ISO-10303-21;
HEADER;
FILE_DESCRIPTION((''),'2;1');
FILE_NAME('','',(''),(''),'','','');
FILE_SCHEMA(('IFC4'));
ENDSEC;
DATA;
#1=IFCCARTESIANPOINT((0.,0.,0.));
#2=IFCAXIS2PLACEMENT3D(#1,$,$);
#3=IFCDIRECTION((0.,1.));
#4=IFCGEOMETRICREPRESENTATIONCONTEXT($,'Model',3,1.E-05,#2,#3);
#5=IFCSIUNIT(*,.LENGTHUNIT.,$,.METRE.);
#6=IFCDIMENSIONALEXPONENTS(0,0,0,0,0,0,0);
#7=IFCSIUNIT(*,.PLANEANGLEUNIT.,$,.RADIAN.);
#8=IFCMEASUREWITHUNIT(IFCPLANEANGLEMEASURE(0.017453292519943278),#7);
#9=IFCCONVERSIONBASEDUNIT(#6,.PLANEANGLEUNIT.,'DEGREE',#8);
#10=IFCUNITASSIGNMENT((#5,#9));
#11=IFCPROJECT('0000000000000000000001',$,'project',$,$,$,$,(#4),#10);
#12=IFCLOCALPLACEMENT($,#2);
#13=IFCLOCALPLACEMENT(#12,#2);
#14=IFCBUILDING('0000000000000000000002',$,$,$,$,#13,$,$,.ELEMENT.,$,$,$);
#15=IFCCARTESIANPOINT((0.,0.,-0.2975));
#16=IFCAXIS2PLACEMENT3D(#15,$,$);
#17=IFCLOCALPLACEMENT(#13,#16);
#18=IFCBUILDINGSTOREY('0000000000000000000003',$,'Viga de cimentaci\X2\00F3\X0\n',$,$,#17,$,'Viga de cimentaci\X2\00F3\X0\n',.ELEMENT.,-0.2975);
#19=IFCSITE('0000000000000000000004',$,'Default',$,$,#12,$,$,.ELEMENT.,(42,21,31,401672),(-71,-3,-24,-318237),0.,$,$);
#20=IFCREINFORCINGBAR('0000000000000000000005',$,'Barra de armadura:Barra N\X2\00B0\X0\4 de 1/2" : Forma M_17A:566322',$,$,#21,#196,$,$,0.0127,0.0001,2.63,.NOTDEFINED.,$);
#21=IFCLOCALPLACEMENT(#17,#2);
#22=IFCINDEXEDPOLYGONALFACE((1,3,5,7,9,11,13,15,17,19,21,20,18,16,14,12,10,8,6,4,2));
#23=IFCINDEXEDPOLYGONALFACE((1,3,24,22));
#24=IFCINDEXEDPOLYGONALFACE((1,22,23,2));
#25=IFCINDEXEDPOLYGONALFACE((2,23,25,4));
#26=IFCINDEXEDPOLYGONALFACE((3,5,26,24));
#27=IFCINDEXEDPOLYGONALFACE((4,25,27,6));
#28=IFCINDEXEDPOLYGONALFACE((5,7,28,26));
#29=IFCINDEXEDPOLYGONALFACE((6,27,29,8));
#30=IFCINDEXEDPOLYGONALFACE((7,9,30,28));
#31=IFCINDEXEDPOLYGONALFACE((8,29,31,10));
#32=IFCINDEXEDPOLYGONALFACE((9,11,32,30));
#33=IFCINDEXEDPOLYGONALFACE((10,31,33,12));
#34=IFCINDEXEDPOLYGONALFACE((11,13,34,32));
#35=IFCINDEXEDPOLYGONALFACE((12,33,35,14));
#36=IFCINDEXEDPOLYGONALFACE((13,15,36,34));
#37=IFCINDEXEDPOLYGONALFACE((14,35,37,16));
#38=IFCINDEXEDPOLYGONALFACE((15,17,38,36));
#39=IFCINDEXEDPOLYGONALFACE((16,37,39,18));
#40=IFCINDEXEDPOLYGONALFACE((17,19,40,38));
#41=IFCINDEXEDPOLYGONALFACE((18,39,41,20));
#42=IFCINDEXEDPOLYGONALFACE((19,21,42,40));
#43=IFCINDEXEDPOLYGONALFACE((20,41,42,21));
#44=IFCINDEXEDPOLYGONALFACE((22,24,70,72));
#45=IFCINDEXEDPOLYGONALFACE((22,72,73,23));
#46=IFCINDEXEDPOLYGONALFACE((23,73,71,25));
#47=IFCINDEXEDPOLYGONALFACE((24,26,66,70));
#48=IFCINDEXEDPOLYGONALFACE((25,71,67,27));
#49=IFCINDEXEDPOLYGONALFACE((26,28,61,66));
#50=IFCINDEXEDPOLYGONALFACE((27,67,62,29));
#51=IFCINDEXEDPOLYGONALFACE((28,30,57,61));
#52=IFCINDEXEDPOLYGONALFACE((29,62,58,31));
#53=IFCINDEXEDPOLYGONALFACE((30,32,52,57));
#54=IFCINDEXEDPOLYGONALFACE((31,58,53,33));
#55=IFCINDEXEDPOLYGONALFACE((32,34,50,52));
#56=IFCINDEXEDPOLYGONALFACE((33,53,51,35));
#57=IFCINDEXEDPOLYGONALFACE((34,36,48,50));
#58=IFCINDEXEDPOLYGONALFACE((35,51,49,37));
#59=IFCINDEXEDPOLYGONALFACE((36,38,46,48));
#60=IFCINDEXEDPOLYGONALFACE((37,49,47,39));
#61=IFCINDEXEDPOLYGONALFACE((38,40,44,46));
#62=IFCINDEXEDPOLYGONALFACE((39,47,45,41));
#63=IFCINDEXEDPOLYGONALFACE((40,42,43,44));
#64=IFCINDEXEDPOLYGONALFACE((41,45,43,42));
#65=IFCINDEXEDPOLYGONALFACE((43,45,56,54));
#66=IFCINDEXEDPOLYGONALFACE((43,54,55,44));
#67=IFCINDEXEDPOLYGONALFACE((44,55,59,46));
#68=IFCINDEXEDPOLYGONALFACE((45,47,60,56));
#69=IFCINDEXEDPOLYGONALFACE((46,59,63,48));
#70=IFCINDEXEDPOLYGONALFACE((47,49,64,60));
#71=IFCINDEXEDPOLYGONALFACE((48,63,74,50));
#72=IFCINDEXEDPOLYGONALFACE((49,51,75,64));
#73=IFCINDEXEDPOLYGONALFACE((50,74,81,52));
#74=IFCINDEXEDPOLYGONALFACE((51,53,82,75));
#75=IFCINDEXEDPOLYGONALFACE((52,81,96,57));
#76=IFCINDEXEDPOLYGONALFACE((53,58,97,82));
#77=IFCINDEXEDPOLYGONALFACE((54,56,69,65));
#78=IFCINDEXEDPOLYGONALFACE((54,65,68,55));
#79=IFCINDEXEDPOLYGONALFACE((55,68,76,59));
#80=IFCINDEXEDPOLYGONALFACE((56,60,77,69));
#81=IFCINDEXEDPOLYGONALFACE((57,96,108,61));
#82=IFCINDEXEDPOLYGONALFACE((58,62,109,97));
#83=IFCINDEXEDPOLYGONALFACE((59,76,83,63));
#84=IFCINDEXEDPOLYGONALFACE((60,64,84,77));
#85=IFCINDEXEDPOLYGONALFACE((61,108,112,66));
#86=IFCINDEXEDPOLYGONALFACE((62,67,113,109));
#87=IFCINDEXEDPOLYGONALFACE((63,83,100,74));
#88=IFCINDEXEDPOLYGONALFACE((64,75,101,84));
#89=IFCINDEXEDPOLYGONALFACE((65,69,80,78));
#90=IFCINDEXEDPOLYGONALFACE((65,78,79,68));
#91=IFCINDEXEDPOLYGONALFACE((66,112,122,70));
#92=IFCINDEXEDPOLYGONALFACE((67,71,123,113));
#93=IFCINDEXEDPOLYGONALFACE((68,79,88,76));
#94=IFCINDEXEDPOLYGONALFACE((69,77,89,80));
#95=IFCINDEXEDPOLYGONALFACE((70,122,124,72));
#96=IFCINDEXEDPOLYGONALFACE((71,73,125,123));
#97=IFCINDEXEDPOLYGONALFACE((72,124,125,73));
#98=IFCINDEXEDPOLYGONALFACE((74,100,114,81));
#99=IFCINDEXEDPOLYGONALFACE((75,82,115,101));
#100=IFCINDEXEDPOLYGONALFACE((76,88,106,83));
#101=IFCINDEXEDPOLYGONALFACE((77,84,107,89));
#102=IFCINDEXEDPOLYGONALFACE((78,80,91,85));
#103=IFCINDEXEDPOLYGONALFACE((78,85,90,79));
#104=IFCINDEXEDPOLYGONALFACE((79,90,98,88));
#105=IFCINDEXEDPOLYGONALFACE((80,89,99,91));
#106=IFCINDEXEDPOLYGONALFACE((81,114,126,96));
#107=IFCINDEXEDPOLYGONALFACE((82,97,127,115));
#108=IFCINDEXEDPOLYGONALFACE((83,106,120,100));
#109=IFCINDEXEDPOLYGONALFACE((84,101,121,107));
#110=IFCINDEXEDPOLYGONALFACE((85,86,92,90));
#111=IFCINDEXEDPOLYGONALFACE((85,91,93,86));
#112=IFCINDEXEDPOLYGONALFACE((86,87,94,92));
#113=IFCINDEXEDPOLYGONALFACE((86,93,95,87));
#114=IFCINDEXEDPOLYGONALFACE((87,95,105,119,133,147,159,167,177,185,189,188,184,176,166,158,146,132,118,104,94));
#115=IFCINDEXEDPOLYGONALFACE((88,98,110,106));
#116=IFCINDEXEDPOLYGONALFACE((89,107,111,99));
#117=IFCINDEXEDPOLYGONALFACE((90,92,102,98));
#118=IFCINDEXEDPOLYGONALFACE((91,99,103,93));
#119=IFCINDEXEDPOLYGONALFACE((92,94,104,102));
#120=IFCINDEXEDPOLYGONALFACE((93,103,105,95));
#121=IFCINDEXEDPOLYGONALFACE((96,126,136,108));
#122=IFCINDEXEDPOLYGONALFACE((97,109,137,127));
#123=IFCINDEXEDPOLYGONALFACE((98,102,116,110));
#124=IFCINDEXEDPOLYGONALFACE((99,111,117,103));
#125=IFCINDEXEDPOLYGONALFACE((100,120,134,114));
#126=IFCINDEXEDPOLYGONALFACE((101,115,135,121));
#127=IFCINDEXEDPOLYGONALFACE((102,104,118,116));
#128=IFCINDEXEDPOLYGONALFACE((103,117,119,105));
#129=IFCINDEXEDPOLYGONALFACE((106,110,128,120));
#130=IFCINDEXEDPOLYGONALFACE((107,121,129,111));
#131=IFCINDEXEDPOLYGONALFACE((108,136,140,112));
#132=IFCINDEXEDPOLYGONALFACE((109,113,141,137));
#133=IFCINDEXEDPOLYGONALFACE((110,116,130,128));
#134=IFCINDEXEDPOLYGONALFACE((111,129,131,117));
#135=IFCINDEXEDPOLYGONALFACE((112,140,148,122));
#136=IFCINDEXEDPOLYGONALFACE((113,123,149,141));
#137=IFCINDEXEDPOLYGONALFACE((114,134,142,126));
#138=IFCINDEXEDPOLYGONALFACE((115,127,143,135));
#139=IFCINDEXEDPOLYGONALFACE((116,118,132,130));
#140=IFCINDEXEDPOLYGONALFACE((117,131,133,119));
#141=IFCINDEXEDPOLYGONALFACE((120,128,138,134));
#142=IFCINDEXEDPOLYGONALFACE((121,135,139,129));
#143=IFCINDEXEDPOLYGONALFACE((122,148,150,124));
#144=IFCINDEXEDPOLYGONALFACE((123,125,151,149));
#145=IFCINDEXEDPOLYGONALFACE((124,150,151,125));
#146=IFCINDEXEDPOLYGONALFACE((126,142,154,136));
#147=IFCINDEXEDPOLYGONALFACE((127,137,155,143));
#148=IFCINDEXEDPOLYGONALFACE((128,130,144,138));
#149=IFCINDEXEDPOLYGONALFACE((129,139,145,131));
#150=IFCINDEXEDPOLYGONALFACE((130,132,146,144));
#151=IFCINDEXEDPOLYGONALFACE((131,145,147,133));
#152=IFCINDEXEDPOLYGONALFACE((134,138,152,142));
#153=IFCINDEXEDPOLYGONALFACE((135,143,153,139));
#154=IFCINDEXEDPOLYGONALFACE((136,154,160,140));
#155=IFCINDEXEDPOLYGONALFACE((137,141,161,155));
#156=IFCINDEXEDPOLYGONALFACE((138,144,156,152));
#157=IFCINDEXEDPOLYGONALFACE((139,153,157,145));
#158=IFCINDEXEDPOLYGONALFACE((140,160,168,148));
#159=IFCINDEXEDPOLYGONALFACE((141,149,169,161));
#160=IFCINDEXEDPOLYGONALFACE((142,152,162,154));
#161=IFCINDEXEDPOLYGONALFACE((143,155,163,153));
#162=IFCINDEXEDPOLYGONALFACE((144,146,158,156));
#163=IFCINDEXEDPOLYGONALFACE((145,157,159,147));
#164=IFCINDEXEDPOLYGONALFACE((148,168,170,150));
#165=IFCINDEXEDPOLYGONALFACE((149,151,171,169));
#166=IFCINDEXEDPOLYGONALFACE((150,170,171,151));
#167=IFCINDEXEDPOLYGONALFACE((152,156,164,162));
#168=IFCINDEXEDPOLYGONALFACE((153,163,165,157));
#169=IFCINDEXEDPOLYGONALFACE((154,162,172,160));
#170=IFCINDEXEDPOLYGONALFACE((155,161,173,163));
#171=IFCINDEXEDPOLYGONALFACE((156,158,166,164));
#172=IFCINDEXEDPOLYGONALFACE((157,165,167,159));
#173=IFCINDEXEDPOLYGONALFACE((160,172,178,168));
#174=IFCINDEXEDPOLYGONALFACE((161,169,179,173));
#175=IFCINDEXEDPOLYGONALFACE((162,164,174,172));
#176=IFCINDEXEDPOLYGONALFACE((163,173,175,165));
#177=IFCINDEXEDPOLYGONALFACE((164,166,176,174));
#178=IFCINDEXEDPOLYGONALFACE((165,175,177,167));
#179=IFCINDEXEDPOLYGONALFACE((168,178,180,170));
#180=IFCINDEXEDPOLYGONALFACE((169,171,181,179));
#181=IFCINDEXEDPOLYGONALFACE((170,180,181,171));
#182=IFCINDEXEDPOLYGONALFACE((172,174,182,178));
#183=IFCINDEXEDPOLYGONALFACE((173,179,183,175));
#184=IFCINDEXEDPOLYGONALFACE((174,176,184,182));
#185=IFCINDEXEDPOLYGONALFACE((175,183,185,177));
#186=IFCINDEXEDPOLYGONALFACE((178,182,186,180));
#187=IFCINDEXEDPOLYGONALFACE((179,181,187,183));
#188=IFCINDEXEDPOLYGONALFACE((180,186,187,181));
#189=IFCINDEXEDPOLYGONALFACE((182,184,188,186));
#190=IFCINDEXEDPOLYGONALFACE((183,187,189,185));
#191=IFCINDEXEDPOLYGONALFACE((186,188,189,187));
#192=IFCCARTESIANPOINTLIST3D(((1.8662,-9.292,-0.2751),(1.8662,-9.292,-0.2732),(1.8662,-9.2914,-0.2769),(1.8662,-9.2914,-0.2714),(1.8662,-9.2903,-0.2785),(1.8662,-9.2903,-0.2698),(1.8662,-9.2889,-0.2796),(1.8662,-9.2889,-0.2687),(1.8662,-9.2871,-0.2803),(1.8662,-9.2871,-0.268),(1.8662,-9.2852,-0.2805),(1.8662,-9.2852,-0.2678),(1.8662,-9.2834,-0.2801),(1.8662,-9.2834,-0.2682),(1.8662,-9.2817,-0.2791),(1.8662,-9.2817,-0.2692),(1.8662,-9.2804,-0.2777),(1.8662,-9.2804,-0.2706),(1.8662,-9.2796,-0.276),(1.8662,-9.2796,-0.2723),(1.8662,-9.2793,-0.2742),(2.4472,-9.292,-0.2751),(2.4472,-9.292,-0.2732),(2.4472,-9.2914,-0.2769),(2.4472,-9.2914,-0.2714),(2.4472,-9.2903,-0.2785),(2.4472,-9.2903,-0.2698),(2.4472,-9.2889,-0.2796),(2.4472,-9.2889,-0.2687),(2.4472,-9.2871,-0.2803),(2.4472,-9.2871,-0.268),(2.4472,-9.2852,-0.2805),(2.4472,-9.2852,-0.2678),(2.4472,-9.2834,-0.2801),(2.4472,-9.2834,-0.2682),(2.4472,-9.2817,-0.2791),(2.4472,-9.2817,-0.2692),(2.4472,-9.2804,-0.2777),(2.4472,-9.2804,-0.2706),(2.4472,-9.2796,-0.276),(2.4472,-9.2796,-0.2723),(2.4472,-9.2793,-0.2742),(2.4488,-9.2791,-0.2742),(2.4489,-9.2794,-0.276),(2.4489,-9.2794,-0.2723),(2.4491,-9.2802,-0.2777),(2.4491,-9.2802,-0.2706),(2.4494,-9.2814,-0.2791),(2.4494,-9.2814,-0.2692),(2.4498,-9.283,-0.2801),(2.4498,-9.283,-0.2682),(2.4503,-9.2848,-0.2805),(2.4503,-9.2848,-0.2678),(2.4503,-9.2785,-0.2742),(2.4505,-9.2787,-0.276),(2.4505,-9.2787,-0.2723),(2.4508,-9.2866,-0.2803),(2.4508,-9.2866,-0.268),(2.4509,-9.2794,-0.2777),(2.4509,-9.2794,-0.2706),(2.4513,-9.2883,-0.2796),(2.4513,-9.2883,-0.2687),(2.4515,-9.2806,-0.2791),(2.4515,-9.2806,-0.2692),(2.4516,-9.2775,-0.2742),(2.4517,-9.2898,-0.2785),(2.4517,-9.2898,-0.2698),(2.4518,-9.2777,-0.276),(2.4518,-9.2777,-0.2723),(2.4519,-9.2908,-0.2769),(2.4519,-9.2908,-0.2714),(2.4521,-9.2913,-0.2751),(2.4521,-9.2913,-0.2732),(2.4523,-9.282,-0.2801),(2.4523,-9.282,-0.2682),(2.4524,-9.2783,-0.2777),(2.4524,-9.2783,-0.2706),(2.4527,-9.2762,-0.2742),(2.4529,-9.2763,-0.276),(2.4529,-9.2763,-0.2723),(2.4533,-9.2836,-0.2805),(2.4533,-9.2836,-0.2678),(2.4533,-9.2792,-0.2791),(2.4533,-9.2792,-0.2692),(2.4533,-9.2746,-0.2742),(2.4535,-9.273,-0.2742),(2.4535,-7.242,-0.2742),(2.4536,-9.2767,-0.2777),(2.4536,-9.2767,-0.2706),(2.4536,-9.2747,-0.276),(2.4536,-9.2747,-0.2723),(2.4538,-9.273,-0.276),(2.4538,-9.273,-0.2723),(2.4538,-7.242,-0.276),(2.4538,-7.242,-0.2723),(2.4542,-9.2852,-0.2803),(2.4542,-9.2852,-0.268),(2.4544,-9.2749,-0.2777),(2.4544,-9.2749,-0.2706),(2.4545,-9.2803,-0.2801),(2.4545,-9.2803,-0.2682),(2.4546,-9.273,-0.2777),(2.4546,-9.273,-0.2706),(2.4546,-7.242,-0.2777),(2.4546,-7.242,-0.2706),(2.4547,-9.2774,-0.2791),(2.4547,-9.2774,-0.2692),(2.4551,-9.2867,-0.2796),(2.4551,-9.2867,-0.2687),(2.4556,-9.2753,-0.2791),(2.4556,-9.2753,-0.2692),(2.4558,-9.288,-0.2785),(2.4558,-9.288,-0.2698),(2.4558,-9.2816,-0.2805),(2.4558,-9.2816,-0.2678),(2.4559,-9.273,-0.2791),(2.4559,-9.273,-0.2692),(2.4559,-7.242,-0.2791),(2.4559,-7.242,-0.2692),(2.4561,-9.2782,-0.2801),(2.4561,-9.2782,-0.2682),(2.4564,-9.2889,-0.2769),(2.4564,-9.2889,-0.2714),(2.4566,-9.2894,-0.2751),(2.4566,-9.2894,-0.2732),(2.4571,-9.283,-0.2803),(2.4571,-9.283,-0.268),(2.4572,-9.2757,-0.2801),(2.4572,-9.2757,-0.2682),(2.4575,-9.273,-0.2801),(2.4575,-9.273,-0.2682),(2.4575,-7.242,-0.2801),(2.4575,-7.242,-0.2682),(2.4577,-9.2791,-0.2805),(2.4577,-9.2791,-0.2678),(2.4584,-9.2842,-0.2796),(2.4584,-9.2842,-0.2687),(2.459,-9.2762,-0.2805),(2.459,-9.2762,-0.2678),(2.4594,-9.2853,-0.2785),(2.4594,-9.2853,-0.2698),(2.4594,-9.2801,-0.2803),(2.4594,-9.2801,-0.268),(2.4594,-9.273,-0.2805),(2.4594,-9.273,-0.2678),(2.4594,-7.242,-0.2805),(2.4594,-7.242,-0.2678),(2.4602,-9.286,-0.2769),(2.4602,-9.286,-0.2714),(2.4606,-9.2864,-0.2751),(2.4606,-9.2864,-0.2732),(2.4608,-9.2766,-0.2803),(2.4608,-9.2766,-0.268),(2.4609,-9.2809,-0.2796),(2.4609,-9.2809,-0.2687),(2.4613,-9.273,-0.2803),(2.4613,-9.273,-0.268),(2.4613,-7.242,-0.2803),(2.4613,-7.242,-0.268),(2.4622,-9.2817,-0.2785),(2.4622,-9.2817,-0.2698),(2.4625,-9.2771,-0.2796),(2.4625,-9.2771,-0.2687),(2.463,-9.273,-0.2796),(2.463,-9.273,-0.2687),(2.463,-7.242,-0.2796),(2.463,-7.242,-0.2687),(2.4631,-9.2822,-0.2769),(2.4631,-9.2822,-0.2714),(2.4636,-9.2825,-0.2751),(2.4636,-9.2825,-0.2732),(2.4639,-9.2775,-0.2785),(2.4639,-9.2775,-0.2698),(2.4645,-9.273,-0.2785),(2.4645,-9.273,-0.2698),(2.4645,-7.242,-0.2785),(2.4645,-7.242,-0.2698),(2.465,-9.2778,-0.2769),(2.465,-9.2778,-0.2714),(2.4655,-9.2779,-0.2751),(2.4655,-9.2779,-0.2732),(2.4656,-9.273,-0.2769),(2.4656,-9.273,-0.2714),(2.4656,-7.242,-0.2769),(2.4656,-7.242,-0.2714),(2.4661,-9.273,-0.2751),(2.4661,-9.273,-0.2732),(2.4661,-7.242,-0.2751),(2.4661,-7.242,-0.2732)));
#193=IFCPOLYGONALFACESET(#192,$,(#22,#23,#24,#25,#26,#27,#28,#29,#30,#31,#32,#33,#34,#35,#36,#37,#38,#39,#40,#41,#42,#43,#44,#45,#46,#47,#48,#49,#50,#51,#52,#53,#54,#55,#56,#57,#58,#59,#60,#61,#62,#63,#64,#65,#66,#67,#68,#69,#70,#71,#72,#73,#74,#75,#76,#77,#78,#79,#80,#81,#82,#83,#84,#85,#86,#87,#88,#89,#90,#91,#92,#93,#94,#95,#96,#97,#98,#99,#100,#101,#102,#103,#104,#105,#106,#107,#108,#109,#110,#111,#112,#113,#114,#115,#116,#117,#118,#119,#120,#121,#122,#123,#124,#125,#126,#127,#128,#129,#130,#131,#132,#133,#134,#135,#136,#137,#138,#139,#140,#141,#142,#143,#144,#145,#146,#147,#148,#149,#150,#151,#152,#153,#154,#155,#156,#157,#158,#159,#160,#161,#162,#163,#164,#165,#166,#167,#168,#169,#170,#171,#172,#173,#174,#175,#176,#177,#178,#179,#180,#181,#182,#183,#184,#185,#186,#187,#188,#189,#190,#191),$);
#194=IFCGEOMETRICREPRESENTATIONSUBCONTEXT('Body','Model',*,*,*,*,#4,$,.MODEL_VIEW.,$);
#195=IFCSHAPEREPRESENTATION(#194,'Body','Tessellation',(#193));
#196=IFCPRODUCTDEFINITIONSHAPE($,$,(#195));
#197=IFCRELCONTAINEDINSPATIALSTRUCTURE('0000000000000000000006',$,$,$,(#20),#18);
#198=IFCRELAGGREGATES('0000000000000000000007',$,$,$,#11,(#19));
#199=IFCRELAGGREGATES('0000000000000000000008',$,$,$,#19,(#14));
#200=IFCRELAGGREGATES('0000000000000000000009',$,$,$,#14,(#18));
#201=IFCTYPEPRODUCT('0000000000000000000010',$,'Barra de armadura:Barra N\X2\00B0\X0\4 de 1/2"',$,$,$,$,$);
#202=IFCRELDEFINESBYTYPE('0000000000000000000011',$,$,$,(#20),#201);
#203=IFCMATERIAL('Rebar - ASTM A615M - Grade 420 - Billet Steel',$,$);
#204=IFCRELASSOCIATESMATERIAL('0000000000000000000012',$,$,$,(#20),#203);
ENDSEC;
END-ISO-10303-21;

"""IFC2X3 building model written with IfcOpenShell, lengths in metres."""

from ifc_helpers import new_model, entity, si_unit, converted_unit, direction, frame, origin, place, context, subcontext, project, spatial, material, type_object, element, save


model = new_model("IFC2X3")

# Units and contexts
model_context = context("Model", 3, precision=1e-05, world=origin(), true_north=direction((0.0, 1.0)))
body_context = subcontext(model_context, "Body", "Model", "MODEL_VIEW")
ifc_project = project(units=[si_unit("LENGTHUNIT", "METRE"), converted_unit("PLANEANGLEUNIT", "DEGREE", entity("IfcPlaneAngleMeasure", 0.017453292519943278), si_unit("PLANEANGLEUNIT", "RADIAN"), dimensions=[0, 0, 0, 0, 0, 0, 0])], contexts=[model_context])

# Site, building, storey
site_placement = place(None, origin())
site = spatial("IfcSite", under=ifc_project, at=site_placement, Name="Default", CompositionType="ELEMENT", RefLatitude=(42, 21, 31, 401672), RefLongitude=(-71, -3, -24, -318237), RefElevation=0.0)
building_placement = place(site_placement, origin())
building = spatial("IfcBuilding", under=site, at=building_placement, CompositionType="ELEMENT")
storey_placement = place(building_placement, frame((0.0, 0.0, -0.2975)))
storey = spatial("IfcBuildingStorey", under=building, at=storey_placement, Name="Viga de cimentación", LongName="Viga de cimentación", CompositionType="ELEMENT", Elevation=-0.2975)

# Reinforcing bar
ifc_material = material(Name="Rebar - ASTM A615M - Grade 420 - Billet Steel")
type_product_1 = type_object("IfcTypeProduct", Name="Barra de armadura:Barra N°4 de 1/2\"")
reinforcing_bar_1_placement = place(storey_placement, origin())
element("IfcReinforcingBar", 1, at=reinforcing_bar_1_placement, inside=storey, type_object=type_product_1, material=ifc_material, Name="Barra de armadura:Barra N°4 de 1/2\" : Forma M_17A:566322", BarLength=2.63, BarRole="NOTDEFINED", CrossSectionArea=0.0001, NominalDiameter=0.0127, context=body_context, shape_type="AdvancedSweptSolid", body=[
    entity("IfcSweptDiskSolid", entity("IfcCompositeCurve", [entity("IfcCompositeCurveSegment", "CONTINUOUS", True, entity("IfcPolyline", [entity("IfcCartesianPoint", [1.8662, -9.2857, -0.2742]), entity("IfcCartesianPoint", [2.4472, -9.2857, -0.2742])])), entity("IfcCompositeCurveSegment", "CONTINUOUS", True, entity("IfcTrimmedCurve", entity("IfcCircle", entity("IfcAxis2Placement3D", entity("IfcCartesianPoint", [2.4472, -9.273, -0.2742])), 0.0127), [entity("IfcParameterValue", 270.0)], [entity("IfcParameterValue", 360.0)], True, "PARAMETER")), entity("IfcCompositeCurveSegment", "CONTINUOUS", True, entity("IfcPolyline", [entity("IfcCartesianPoint", [2.4599, -9.273, -0.2742]), entity("IfcCartesianPoint", [2.4599, -7.242, -0.2742])]))], False), 0.0063, None, 0.0, 92.0),
])

save(model, "model.ifc")
